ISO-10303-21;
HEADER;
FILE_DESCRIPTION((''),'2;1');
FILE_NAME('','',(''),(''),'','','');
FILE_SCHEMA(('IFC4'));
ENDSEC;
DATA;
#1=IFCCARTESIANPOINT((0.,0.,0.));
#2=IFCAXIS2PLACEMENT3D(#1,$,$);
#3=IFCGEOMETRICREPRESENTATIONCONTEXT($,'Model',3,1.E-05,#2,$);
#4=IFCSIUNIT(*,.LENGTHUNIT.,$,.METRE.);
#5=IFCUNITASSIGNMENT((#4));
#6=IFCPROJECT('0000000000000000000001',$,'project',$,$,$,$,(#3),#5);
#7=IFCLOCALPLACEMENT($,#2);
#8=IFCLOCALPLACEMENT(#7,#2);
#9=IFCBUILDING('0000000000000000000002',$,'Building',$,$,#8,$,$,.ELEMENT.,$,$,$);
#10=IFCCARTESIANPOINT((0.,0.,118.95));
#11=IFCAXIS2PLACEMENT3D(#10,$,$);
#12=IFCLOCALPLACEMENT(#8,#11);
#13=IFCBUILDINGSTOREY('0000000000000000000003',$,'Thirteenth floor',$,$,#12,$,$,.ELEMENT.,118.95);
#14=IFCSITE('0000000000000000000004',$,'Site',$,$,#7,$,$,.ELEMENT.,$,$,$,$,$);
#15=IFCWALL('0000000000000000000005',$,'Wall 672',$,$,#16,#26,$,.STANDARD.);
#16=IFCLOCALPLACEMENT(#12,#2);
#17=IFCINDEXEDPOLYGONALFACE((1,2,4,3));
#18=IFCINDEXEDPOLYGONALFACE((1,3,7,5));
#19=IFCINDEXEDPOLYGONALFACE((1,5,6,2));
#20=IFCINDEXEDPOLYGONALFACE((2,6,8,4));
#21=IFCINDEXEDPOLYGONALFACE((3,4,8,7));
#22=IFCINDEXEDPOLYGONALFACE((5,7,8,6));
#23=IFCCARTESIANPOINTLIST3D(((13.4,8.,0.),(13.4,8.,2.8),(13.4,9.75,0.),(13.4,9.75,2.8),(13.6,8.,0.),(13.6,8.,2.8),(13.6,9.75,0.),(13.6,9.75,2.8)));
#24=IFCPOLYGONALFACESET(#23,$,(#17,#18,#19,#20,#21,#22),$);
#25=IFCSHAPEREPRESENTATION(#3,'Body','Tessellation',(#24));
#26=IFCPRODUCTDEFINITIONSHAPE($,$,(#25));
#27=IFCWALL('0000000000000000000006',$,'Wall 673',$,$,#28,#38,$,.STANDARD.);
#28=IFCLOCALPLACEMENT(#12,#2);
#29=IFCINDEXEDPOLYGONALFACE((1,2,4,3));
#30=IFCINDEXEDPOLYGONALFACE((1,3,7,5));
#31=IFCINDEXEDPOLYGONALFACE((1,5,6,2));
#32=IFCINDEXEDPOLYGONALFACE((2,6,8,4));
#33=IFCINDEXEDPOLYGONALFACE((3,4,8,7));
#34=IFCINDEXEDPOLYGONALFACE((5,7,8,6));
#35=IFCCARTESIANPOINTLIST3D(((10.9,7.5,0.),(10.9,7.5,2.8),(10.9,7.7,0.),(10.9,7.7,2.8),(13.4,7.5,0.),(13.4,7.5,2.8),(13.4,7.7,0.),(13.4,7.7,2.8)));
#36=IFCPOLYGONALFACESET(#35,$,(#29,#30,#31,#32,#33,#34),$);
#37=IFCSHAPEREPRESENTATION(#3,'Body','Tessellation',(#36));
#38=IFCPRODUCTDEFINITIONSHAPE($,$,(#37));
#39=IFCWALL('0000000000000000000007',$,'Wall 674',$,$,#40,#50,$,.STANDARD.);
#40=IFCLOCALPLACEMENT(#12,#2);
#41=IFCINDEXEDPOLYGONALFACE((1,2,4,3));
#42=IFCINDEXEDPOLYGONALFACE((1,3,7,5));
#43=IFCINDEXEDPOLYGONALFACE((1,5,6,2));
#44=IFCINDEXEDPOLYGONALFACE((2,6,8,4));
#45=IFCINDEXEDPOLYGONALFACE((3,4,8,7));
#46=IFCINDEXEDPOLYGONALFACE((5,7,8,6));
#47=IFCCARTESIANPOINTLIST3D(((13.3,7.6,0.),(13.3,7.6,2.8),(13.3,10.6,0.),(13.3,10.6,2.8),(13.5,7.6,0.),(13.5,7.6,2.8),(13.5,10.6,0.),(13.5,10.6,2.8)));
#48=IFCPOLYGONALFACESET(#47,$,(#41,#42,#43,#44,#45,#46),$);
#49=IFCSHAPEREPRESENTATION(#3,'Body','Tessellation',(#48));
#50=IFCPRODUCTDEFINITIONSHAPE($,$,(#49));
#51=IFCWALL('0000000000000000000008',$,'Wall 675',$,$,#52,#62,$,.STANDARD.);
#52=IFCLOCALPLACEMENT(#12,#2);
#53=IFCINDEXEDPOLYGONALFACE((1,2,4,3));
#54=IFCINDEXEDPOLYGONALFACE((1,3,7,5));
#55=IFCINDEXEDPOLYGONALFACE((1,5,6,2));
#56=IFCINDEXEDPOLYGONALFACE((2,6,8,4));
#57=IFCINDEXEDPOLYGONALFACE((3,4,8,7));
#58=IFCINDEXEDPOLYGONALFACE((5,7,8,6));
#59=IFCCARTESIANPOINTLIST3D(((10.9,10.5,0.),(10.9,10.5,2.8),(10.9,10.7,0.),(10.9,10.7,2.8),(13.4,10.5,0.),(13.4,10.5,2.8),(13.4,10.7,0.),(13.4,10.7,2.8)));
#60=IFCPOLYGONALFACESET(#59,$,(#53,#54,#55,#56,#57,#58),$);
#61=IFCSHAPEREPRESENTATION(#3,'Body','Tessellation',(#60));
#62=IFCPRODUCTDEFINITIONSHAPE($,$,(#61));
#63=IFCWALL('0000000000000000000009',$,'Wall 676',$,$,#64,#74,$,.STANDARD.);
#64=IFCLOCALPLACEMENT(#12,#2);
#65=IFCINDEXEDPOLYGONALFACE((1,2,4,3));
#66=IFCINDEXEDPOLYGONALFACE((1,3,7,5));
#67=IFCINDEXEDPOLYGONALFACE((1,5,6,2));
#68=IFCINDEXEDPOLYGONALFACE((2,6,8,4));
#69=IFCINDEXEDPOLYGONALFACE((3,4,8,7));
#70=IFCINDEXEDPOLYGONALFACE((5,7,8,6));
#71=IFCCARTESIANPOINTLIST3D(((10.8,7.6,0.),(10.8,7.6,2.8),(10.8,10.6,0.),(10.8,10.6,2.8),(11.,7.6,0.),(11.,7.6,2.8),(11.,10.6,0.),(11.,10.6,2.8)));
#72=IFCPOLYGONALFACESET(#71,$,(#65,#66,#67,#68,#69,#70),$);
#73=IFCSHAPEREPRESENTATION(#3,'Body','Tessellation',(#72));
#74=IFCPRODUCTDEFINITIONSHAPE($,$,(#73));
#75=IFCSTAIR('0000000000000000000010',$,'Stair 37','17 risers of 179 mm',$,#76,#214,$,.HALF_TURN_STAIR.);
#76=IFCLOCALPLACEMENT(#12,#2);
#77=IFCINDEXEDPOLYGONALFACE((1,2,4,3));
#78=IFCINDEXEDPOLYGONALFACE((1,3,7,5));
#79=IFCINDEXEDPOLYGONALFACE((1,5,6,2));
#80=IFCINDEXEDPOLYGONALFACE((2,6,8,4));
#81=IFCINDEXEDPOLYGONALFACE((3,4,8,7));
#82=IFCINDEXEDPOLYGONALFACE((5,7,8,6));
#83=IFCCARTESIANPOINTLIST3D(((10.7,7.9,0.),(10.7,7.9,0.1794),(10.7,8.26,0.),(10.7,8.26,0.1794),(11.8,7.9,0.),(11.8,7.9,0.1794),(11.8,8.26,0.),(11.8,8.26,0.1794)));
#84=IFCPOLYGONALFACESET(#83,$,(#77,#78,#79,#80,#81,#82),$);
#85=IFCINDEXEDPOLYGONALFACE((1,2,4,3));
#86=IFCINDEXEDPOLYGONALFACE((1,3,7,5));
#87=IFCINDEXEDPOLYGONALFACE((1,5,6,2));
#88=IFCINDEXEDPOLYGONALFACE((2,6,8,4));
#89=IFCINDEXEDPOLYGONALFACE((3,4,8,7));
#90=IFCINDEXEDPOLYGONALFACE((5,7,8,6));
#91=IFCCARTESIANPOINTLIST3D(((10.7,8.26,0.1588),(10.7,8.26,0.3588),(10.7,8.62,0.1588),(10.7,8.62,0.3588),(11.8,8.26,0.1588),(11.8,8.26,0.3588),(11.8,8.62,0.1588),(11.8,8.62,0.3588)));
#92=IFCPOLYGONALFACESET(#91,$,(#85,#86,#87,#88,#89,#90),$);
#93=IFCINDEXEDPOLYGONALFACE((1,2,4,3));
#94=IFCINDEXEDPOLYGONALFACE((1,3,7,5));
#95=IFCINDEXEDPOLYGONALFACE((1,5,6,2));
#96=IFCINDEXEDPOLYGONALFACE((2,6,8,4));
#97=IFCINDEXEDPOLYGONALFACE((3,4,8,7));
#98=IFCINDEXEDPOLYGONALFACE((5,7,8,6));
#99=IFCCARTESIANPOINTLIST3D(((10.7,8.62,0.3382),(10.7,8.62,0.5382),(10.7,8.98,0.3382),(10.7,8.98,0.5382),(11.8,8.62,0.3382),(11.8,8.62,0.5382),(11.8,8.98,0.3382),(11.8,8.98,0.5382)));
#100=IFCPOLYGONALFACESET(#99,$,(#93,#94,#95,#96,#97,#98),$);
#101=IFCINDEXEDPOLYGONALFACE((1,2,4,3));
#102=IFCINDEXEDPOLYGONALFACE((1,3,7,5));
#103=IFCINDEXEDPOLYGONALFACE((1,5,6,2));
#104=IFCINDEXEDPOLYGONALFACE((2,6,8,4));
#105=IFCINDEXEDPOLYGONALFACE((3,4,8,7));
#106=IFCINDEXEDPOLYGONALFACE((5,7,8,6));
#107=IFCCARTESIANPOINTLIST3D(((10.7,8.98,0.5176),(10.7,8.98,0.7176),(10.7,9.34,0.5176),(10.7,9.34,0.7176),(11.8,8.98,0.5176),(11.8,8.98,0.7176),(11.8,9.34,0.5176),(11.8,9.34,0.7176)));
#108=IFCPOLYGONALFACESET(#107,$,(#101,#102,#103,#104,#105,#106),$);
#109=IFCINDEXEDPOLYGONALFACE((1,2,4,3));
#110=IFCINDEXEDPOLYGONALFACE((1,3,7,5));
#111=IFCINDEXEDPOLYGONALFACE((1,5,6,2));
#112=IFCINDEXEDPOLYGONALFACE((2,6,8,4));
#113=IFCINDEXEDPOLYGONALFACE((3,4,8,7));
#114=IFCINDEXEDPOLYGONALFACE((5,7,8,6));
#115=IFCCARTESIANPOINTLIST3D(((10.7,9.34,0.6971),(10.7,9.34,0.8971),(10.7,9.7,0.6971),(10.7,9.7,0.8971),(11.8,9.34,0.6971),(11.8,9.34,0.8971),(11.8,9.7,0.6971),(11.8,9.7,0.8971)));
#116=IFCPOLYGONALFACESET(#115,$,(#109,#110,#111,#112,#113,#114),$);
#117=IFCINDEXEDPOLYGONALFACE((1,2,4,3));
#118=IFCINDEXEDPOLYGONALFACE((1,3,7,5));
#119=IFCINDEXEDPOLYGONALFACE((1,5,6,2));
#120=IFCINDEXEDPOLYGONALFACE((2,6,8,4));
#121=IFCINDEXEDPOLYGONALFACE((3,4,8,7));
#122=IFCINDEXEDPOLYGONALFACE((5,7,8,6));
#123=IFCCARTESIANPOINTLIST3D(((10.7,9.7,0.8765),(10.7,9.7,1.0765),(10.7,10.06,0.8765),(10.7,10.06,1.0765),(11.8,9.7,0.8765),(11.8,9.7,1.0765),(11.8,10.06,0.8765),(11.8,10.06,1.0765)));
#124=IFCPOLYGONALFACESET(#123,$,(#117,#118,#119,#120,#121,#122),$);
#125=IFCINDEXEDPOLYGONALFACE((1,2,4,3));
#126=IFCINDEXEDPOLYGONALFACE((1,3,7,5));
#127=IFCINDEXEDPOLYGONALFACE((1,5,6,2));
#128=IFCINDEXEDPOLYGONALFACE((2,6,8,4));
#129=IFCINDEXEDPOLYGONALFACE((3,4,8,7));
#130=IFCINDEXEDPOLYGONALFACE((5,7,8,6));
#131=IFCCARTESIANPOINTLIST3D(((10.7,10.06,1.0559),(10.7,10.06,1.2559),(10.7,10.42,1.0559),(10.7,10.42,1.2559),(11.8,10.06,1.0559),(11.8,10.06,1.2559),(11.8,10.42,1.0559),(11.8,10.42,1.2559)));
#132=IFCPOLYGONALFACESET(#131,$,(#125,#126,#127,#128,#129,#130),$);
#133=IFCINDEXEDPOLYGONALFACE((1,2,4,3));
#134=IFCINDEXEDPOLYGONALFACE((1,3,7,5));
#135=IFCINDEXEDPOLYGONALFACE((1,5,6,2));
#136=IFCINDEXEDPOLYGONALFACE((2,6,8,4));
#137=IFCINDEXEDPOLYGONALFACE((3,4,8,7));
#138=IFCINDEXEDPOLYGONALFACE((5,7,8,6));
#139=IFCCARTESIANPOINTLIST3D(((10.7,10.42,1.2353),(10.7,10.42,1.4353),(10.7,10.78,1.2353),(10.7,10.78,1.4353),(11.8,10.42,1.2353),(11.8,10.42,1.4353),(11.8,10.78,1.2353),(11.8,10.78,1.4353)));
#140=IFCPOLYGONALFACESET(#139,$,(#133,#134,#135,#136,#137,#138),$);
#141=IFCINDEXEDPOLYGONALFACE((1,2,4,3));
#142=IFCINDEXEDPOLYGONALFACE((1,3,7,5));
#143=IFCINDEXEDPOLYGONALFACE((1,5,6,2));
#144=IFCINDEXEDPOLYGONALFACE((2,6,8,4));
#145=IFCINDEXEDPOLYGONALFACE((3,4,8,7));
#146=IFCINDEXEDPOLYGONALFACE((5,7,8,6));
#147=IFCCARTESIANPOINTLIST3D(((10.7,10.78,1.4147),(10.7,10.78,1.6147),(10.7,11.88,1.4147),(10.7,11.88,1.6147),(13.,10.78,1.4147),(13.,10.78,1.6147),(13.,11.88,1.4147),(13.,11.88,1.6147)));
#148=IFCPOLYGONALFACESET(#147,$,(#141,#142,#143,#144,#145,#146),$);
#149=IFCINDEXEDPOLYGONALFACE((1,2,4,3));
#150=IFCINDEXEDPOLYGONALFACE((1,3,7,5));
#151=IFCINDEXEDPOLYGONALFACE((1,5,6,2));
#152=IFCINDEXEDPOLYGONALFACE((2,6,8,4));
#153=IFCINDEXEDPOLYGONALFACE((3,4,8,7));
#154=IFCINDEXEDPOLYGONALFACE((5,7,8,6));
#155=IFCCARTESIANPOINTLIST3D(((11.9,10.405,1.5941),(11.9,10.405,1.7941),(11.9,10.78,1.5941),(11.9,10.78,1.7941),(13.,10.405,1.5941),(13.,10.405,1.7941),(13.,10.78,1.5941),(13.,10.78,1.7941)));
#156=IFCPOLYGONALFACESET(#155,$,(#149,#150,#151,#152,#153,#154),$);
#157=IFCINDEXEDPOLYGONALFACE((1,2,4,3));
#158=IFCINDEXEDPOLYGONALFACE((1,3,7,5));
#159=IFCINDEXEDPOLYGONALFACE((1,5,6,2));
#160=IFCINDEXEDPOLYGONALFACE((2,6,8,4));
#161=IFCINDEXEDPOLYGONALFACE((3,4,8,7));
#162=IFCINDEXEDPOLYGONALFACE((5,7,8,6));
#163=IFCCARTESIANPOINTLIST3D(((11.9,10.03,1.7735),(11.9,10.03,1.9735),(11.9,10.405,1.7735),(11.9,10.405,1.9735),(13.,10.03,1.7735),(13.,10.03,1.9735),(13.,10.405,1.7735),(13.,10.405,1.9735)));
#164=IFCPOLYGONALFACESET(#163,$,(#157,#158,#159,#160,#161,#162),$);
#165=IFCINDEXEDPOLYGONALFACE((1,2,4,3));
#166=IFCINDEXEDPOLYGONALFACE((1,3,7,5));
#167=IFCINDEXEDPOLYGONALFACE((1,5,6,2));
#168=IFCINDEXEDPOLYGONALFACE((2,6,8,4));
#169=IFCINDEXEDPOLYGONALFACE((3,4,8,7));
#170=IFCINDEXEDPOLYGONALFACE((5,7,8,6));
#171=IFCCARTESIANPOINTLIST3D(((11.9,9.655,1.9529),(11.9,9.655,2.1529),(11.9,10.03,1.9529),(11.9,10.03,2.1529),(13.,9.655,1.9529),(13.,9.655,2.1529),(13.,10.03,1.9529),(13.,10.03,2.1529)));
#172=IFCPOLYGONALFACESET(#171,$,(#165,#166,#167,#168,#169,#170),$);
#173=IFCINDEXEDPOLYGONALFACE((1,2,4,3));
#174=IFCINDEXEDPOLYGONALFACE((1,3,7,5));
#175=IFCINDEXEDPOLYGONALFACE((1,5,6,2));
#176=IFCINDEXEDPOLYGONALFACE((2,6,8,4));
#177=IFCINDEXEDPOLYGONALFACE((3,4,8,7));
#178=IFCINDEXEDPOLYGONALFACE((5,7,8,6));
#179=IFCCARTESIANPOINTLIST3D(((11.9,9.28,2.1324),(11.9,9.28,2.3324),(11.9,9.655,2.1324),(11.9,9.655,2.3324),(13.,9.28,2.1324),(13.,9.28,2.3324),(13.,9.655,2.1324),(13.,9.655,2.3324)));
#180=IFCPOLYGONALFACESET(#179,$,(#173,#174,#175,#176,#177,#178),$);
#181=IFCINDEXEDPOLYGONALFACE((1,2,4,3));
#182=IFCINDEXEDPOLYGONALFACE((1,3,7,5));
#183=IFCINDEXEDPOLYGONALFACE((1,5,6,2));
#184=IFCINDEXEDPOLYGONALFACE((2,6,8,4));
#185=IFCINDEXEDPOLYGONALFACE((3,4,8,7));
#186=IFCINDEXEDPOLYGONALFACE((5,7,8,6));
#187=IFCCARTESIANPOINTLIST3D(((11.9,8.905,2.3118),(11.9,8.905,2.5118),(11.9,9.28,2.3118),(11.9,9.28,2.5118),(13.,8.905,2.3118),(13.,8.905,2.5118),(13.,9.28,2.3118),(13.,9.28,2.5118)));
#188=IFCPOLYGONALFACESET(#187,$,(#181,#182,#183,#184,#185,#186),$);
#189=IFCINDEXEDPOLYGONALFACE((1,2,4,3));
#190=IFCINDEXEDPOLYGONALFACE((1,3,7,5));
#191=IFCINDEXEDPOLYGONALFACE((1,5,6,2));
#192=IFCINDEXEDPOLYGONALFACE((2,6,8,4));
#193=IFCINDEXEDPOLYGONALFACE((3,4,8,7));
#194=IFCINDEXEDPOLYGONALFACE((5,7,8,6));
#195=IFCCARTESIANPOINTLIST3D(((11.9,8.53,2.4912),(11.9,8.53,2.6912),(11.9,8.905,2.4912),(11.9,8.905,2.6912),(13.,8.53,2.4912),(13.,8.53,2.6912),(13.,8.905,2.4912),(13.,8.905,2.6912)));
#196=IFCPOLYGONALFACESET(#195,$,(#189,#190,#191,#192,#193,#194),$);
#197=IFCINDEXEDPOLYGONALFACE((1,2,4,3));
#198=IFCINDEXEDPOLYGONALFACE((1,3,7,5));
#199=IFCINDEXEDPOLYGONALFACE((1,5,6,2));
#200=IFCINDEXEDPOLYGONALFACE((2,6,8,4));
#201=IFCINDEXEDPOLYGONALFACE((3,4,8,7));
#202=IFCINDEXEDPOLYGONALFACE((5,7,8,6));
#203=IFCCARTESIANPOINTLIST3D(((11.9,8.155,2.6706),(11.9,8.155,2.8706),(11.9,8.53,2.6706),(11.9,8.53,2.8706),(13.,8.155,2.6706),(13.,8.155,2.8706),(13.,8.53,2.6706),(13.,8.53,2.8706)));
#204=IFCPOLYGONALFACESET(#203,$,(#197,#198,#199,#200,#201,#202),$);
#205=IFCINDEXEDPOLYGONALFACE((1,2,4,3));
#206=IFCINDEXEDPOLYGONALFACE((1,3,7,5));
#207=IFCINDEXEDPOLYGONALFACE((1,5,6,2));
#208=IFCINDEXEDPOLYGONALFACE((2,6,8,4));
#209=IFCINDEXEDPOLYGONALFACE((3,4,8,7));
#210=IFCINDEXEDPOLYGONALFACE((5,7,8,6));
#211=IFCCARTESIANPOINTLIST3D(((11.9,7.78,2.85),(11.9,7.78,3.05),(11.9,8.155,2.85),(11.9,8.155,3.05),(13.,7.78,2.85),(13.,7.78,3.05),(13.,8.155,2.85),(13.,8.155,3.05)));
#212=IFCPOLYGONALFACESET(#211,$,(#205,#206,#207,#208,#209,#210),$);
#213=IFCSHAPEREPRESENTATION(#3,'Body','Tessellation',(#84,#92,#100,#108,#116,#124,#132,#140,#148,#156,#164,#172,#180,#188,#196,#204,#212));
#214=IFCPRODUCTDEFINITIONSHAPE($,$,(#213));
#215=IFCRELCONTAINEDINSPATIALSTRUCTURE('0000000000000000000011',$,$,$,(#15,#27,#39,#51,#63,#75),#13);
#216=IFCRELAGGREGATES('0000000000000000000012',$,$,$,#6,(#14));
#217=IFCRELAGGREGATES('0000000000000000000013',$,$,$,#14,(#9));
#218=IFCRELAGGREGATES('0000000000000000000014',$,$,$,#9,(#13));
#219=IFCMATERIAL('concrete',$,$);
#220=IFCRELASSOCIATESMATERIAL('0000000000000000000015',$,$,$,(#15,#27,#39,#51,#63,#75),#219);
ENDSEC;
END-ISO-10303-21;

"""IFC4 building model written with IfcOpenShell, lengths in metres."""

from ifc_helpers import new_model, si_unit, frame, frame_2d, origin, place, context, project, spatial, polyline, rectangle, outline, extrude, material, element, save


model = new_model("IFC4")

# Units and contexts
model_context = context("Model", 3, precision=1e-05, world=origin())
ifc_project = project(units=[si_unit("LENGTHUNIT", "METRE")], contexts=[model_context])

# Site, building, storey
site_placement = place(None, origin())
site = spatial("IfcSite", under=ifc_project, at=site_placement, Name="Site", CompositionType="ELEMENT")
building_placement = place(site_placement, origin())
building = spatial("IfcBuilding", under=site, at=building_placement, Name="Building", CompositionType="ELEMENT")
storey_placement = place(building_placement, frame((0.0, 0.0, 118.95)))
storey = spatial("IfcBuildingStorey", under=building, at=storey_placement, Name="Thirteenth floor", CompositionType="ELEMENT", Elevation=118.95)

# Shared definitions
ifc_material = material(Name="concrete")

# Walls
wall_1_placement = place(storey_placement, frame((13.5, 9.75, 0.0), z_axis=(0.0, 0.0, 1.0), x_axis=(0.0, -1.0, 0.0)))
element("IfcWall", 1, at=wall_1_placement, inside=storey, material=ifc_material, Name="Wall 672", PredefinedType="STANDARD", context=model_context, shape_type="SweptSolid", body=[
    extrude(rectangle(XDim=1.75, YDim=0.2, at=frame_2d((0.875, 0.0))), origin(), (0.0, 0.0, 1.0), 2.8),
])
wall_2_placement = place(storey_placement, frame((10.9, 7.6, 0.0), z_axis=(0.0, 0.0, 1.0), x_axis=(1.0, 0.0, 0.0)))
element("IfcWall", 2, at=wall_2_placement, inside=storey, material=ifc_material, Name="Wall 673", PredefinedType="STANDARD", context=model_context, shape_type="SweptSolid", body=[
    extrude(rectangle(XDim=2.5, YDim=0.2, at=frame_2d((1.25, 0.0))), origin(), (0.0, 0.0, 1.0), 2.8),
])
wall_3_placement = place(storey_placement, frame((13.4, 7.6, 0.0), z_axis=(0.0, 0.0, 1.0), x_axis=(0.0, 1.0, 0.0)))
element("IfcWall", 3, at=wall_3_placement, inside=storey, material=ifc_material, Name="Wall 674", PredefinedType="STANDARD", context=model_context, shape_type="SweptSolid", body=[
    extrude(rectangle(XDim=3.0, YDim=0.2, at=frame_2d((1.5, 0.0))), origin(), (0.0, 0.0, 1.0), 2.8),
])
wall_4_placement = place(storey_placement, frame((13.4, 10.6, 0.0), z_axis=(0.0, 0.0, 1.0), x_axis=(-1.0, 0.0, 0.0)))
element("IfcWall", 4, at=wall_4_placement, inside=storey, material=ifc_material, Name="Wall 675", PredefinedType="STANDARD", context=model_context, shape_type="SweptSolid", body=[
    extrude(rectangle(XDim=2.5, YDim=0.2, at=frame_2d((1.25, 0.0))), origin(), (0.0, 0.0, 1.0), 2.8),
])
wall_5_placement = place(storey_placement, frame((10.9, 10.6, 0.0), z_axis=(0.0, 0.0, 1.0), x_axis=(0.0, -1.0, 0.0)))
element("IfcWall", 5, at=wall_5_placement, inside=storey, material=ifc_material, Name="Wall 676", PredefinedType="STANDARD", context=model_context, shape_type="SweptSolid", body=[
    extrude(rectangle(XDim=3.0, YDim=0.2, at=frame_2d((1.5, 0.0))), origin(), (0.0, 0.0, 1.0), 2.8),
])

# Stair
stair_placement = place(storey_placement, frame((11.25, 7.9, 0.0), z_axis=(0.0, 0.0, 1.0), x_axis=(0.0, 1.0, 0.0)))
element("IfcStair", 6, at=stair_placement, inside=storey, material=ifc_material, Name="Stair 37", Description="17 risers of 179 mm", PredefinedType="HALF_TURN_STAIR", context=model_context, shape_type="SweptSolid", body=[
    extrude(outline(polyline([(0.0, -0.55), (0.36, -0.55), (0.36, 0.55), (0.0, 0.55), (0.0, -0.55)])), origin(), (0.0, 0.0, 1.0), 0.1794),
    extrude(outline(polyline([(0.36, -0.55), (0.72, -0.55), (0.72, 0.55), (0.36, 0.55), (0.36, -0.55)])), frame((0.0, 0.0, 0.1588)), (0.0, 0.0, 1.0), 0.2),
    extrude(outline(polyline([(0.72, -0.55), (1.08, -0.55), (1.08, 0.55), (0.72, 0.55), (0.72, -0.55)])), frame((0.0, 0.0, 0.3382)), (0.0, 0.0, 1.0), 0.2),
    extrude(outline(polyline([(1.08, -0.55), (1.44, -0.55), (1.44, 0.55), (1.08, 0.55), (1.08, -0.55)])), frame((0.0, 0.0, 0.5176)), (0.0, 0.0, 1.0), 0.2),
    extrude(outline(polyline([(1.44, -0.55), (1.8, -0.55), (1.8, 0.55), (1.44, 0.55), (1.44, -0.55)])), frame((0.0, 0.0, 0.6971)), (0.0, 0.0, 1.0), 0.2),
    extrude(outline(polyline([(1.8, -0.55), (2.16, -0.55), (2.16, 0.55), (1.8, 0.55), (1.8, -0.55)])), frame((0.0, 0.0, 0.8765)), (0.0, 0.0, 1.0), 0.2),
    extrude(outline(polyline([(2.16, -0.55), (2.52, -0.55), (2.52, 0.55), (2.16, 0.55), (2.16, -0.55)])), frame((0.0, 0.0, 1.0559)), (0.0, 0.0, 1.0), 0.2),
    extrude(outline(polyline([(2.52, -0.55), (2.88, -0.55), (2.88, 0.55), (2.52, 0.55), (2.52, -0.55)])), frame((0.0, 0.0, 1.2353)), (0.0, 0.0, 1.0), 0.2),
    extrude(outline(polyline([(2.88, -1.75), (3.98, -1.75), (3.98, 0.55), (2.88, 0.55), (2.88, -1.75)])), frame((0.0, 0.0, 1.4147)), (0.0, 0.0, 1.0), 0.2),
    extrude(outline(polyline([(2.505, -1.75), (2.88, -1.75), (2.88, -0.65), (2.505, -0.65), (2.505, -1.75)])), frame((0.0, 0.0, 1.5941)), (0.0, 0.0, 1.0), 0.2),
    extrude(outline(polyline([(2.13, -1.75), (2.505, -1.75), (2.505, -0.65), (2.13, -0.65), (2.13, -1.75)])), frame((0.0, 0.0, 1.7735)), (0.0, 0.0, 1.0), 0.2),
    extrude(outline(polyline([(1.755, -1.75), (2.13, -1.75), (2.13, -0.65), (1.755, -0.65), (1.755, -1.75)])), frame((0.0, 0.0, 1.9529)), (0.0, 0.0, 1.0), 0.2),
    extrude(outline(polyline([(1.38, -1.75), (1.755, -1.75), (1.755, -0.65), (1.38, -0.65), (1.38, -1.75)])), frame((0.0, 0.0, 2.1324)), (0.0, 0.0, 1.0), 0.2),
    extrude(outline(polyline([(1.005, -1.75), (1.38, -1.75), (1.38, -0.65), (1.005, -0.65), (1.005, -1.75)])), frame((0.0, 0.0, 2.3118)), (0.0, 0.0, 1.0), 0.2),
    extrude(outline(polyline([(0.63, -1.75), (1.005, -1.75), (1.005, -0.65), (0.63, -0.65), (0.63, -1.75)])), frame((0.0, 0.0, 2.4912)), (0.0, 0.0, 1.0), 0.2),
    extrude(outline(polyline([(0.255, -1.75), (0.63, -1.75), (0.63, -0.65), (0.255, -0.65), (0.255, -1.75)])), frame((0.0, 0.0, 2.6706)), (0.0, 0.0, 1.0), 0.2),
    extrude(outline(polyline([(-0.12, -1.75), (0.255, -1.75), (0.255, -0.65), (-0.12, -0.65), (-0.12, -1.75)])), frame((0.0, 0.0, 2.85)), (0.0, 0.0, 1.0), 0.2),
])

save(model, "model.ifc")
